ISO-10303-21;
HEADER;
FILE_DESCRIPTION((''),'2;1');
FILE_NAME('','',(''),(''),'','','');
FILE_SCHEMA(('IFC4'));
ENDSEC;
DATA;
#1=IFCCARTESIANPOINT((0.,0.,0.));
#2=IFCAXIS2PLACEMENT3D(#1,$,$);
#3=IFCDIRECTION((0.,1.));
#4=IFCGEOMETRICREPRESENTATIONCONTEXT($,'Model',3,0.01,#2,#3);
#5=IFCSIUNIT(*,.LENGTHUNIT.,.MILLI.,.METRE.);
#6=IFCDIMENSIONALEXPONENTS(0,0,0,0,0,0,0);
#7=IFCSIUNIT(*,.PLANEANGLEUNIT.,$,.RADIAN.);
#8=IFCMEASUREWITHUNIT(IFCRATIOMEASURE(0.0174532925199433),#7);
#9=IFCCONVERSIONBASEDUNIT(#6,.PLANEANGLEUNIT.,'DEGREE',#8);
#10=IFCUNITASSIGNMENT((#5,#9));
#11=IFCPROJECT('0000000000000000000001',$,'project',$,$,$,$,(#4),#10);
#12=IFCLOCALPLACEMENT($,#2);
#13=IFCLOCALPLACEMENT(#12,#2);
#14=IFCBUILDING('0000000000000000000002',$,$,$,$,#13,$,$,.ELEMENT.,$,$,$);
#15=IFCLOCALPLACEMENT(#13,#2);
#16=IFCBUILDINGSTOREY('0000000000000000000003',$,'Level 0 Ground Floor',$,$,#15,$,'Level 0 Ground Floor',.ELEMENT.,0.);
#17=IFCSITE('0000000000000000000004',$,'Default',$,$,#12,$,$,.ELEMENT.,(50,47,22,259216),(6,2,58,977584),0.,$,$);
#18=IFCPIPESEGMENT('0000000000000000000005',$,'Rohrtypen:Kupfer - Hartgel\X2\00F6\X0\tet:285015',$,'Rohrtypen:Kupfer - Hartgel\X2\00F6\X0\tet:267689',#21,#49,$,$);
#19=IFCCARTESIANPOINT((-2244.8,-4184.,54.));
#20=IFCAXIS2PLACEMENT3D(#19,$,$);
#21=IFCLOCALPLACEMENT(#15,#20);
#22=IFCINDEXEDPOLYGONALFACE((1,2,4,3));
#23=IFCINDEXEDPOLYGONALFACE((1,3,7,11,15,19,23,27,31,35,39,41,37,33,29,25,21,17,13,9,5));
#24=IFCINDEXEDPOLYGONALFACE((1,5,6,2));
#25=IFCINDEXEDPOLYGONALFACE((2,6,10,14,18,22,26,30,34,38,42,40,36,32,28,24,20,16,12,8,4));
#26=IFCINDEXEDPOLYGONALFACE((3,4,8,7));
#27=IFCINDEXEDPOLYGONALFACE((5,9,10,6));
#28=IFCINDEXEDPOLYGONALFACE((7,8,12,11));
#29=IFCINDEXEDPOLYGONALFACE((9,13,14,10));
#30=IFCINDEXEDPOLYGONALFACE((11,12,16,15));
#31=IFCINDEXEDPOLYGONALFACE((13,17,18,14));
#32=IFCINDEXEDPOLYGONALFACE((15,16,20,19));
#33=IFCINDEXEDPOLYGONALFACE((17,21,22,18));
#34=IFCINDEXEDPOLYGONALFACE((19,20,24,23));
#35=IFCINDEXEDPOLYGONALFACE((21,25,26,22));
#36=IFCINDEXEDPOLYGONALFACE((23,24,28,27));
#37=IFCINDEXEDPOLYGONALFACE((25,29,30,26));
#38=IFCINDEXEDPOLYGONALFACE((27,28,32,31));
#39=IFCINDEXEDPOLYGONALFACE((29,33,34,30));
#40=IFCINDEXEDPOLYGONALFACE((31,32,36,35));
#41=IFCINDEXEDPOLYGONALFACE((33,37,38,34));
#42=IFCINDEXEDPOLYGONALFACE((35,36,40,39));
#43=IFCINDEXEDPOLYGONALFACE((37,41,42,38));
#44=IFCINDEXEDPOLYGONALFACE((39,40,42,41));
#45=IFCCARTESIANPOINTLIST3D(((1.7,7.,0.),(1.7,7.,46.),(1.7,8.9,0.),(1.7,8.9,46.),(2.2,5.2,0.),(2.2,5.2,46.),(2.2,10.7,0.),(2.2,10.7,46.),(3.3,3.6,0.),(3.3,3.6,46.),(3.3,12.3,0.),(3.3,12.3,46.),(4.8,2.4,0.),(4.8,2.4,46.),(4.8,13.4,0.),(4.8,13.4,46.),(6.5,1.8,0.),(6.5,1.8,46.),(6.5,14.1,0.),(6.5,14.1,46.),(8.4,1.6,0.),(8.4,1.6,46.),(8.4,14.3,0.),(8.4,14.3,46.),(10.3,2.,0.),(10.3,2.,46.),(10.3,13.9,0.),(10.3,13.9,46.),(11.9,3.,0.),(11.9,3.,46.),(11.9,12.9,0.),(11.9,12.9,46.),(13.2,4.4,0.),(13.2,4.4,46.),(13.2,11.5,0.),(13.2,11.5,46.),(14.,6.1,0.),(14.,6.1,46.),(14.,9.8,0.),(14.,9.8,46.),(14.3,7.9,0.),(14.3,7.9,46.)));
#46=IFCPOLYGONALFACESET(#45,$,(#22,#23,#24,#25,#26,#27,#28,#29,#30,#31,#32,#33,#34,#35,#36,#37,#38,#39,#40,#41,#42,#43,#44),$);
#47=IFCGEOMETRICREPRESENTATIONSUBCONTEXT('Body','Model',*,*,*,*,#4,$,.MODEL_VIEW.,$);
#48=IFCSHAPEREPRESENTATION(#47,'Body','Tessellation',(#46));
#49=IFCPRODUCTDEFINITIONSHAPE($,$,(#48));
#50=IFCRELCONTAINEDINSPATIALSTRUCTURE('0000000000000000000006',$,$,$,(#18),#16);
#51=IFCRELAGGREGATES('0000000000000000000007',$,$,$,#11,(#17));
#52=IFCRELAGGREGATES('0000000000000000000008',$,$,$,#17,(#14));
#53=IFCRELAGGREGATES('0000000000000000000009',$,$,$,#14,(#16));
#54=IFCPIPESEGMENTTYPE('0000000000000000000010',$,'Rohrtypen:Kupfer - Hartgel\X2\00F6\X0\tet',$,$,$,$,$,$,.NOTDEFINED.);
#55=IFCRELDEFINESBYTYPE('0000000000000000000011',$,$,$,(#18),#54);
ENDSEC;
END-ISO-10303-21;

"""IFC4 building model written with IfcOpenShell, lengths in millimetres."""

from ifc_helpers import new_model, entity, si_unit, converted_unit, direction, frame, origin, origin_2d_with_axis, place, context, subcontext, project, spatial, circle, extrude, type_object, element, save


model = new_model("IFC4")

# Units and contexts
model_context = context("Model", 3, precision=0.01, world=origin(), true_north=direction((0.0, 1.0)))
body_context = subcontext(model_context, "Body", "Model", "MODEL_VIEW")
ifc_project = project(units=[si_unit("LENGTHUNIT", "METRE", prefix="MILLI"), converted_unit("PLANEANGLEUNIT", "DEGREE", entity("IfcRatioMeasure", 0.0174532925199433), si_unit("PLANEANGLEUNIT", "RADIAN"), dimensions=[0, 0, 0, 0, 0, 0, 0])], contexts=[model_context])

# Site, building, storey
site_placement = place(None, origin())
site = spatial("IfcSite", under=ifc_project, at=site_placement, Name="Default", CompositionType="ELEMENT", RefLatitude=(50, 47, 22, 259216), RefLongitude=(6, 2, 58, 977584), RefElevation=0.0)
building_placement = place(site_placement, origin())
building = spatial("IfcBuilding", under=site, at=building_placement, CompositionType="ELEMENT")
storey_placement = place(building_placement, origin())
storey = spatial("IfcBuildingStorey", under=building, at=storey_placement, Name="Level 0 Ground Floor", LongName="Level 0 Ground Floor", CompositionType="ELEMENT", Elevation=0.0)

# Pipe segment
pipe_segment_type = type_object("IfcPipeSegmentType", Name="Rohrtypen:Kupfer - Hartgelötet", PredefinedType="NOTDEFINED")
pipe_segment_1_placement = place(storey_placement, frame((-2244.8, -4184.0, 54.0)))
element("IfcPipeSegment", 1, at=pipe_segment_1_placement, inside=storey, type_object=pipe_segment_type, Name="Rohrtypen:Kupfer - Hartgelötet:285015", ObjectType="Rohrtypen:Kupfer - Hartgelötet:267689", context=body_context, shape_type="SweptSolid", body=[
    extrude(circle(Radius=6.3, at=origin_2d_with_axis()), frame((7.9, 7.9, 0.0)), (0.0, 0.0, 1.0), 46.0),
])

save(model, "model.ifc")
